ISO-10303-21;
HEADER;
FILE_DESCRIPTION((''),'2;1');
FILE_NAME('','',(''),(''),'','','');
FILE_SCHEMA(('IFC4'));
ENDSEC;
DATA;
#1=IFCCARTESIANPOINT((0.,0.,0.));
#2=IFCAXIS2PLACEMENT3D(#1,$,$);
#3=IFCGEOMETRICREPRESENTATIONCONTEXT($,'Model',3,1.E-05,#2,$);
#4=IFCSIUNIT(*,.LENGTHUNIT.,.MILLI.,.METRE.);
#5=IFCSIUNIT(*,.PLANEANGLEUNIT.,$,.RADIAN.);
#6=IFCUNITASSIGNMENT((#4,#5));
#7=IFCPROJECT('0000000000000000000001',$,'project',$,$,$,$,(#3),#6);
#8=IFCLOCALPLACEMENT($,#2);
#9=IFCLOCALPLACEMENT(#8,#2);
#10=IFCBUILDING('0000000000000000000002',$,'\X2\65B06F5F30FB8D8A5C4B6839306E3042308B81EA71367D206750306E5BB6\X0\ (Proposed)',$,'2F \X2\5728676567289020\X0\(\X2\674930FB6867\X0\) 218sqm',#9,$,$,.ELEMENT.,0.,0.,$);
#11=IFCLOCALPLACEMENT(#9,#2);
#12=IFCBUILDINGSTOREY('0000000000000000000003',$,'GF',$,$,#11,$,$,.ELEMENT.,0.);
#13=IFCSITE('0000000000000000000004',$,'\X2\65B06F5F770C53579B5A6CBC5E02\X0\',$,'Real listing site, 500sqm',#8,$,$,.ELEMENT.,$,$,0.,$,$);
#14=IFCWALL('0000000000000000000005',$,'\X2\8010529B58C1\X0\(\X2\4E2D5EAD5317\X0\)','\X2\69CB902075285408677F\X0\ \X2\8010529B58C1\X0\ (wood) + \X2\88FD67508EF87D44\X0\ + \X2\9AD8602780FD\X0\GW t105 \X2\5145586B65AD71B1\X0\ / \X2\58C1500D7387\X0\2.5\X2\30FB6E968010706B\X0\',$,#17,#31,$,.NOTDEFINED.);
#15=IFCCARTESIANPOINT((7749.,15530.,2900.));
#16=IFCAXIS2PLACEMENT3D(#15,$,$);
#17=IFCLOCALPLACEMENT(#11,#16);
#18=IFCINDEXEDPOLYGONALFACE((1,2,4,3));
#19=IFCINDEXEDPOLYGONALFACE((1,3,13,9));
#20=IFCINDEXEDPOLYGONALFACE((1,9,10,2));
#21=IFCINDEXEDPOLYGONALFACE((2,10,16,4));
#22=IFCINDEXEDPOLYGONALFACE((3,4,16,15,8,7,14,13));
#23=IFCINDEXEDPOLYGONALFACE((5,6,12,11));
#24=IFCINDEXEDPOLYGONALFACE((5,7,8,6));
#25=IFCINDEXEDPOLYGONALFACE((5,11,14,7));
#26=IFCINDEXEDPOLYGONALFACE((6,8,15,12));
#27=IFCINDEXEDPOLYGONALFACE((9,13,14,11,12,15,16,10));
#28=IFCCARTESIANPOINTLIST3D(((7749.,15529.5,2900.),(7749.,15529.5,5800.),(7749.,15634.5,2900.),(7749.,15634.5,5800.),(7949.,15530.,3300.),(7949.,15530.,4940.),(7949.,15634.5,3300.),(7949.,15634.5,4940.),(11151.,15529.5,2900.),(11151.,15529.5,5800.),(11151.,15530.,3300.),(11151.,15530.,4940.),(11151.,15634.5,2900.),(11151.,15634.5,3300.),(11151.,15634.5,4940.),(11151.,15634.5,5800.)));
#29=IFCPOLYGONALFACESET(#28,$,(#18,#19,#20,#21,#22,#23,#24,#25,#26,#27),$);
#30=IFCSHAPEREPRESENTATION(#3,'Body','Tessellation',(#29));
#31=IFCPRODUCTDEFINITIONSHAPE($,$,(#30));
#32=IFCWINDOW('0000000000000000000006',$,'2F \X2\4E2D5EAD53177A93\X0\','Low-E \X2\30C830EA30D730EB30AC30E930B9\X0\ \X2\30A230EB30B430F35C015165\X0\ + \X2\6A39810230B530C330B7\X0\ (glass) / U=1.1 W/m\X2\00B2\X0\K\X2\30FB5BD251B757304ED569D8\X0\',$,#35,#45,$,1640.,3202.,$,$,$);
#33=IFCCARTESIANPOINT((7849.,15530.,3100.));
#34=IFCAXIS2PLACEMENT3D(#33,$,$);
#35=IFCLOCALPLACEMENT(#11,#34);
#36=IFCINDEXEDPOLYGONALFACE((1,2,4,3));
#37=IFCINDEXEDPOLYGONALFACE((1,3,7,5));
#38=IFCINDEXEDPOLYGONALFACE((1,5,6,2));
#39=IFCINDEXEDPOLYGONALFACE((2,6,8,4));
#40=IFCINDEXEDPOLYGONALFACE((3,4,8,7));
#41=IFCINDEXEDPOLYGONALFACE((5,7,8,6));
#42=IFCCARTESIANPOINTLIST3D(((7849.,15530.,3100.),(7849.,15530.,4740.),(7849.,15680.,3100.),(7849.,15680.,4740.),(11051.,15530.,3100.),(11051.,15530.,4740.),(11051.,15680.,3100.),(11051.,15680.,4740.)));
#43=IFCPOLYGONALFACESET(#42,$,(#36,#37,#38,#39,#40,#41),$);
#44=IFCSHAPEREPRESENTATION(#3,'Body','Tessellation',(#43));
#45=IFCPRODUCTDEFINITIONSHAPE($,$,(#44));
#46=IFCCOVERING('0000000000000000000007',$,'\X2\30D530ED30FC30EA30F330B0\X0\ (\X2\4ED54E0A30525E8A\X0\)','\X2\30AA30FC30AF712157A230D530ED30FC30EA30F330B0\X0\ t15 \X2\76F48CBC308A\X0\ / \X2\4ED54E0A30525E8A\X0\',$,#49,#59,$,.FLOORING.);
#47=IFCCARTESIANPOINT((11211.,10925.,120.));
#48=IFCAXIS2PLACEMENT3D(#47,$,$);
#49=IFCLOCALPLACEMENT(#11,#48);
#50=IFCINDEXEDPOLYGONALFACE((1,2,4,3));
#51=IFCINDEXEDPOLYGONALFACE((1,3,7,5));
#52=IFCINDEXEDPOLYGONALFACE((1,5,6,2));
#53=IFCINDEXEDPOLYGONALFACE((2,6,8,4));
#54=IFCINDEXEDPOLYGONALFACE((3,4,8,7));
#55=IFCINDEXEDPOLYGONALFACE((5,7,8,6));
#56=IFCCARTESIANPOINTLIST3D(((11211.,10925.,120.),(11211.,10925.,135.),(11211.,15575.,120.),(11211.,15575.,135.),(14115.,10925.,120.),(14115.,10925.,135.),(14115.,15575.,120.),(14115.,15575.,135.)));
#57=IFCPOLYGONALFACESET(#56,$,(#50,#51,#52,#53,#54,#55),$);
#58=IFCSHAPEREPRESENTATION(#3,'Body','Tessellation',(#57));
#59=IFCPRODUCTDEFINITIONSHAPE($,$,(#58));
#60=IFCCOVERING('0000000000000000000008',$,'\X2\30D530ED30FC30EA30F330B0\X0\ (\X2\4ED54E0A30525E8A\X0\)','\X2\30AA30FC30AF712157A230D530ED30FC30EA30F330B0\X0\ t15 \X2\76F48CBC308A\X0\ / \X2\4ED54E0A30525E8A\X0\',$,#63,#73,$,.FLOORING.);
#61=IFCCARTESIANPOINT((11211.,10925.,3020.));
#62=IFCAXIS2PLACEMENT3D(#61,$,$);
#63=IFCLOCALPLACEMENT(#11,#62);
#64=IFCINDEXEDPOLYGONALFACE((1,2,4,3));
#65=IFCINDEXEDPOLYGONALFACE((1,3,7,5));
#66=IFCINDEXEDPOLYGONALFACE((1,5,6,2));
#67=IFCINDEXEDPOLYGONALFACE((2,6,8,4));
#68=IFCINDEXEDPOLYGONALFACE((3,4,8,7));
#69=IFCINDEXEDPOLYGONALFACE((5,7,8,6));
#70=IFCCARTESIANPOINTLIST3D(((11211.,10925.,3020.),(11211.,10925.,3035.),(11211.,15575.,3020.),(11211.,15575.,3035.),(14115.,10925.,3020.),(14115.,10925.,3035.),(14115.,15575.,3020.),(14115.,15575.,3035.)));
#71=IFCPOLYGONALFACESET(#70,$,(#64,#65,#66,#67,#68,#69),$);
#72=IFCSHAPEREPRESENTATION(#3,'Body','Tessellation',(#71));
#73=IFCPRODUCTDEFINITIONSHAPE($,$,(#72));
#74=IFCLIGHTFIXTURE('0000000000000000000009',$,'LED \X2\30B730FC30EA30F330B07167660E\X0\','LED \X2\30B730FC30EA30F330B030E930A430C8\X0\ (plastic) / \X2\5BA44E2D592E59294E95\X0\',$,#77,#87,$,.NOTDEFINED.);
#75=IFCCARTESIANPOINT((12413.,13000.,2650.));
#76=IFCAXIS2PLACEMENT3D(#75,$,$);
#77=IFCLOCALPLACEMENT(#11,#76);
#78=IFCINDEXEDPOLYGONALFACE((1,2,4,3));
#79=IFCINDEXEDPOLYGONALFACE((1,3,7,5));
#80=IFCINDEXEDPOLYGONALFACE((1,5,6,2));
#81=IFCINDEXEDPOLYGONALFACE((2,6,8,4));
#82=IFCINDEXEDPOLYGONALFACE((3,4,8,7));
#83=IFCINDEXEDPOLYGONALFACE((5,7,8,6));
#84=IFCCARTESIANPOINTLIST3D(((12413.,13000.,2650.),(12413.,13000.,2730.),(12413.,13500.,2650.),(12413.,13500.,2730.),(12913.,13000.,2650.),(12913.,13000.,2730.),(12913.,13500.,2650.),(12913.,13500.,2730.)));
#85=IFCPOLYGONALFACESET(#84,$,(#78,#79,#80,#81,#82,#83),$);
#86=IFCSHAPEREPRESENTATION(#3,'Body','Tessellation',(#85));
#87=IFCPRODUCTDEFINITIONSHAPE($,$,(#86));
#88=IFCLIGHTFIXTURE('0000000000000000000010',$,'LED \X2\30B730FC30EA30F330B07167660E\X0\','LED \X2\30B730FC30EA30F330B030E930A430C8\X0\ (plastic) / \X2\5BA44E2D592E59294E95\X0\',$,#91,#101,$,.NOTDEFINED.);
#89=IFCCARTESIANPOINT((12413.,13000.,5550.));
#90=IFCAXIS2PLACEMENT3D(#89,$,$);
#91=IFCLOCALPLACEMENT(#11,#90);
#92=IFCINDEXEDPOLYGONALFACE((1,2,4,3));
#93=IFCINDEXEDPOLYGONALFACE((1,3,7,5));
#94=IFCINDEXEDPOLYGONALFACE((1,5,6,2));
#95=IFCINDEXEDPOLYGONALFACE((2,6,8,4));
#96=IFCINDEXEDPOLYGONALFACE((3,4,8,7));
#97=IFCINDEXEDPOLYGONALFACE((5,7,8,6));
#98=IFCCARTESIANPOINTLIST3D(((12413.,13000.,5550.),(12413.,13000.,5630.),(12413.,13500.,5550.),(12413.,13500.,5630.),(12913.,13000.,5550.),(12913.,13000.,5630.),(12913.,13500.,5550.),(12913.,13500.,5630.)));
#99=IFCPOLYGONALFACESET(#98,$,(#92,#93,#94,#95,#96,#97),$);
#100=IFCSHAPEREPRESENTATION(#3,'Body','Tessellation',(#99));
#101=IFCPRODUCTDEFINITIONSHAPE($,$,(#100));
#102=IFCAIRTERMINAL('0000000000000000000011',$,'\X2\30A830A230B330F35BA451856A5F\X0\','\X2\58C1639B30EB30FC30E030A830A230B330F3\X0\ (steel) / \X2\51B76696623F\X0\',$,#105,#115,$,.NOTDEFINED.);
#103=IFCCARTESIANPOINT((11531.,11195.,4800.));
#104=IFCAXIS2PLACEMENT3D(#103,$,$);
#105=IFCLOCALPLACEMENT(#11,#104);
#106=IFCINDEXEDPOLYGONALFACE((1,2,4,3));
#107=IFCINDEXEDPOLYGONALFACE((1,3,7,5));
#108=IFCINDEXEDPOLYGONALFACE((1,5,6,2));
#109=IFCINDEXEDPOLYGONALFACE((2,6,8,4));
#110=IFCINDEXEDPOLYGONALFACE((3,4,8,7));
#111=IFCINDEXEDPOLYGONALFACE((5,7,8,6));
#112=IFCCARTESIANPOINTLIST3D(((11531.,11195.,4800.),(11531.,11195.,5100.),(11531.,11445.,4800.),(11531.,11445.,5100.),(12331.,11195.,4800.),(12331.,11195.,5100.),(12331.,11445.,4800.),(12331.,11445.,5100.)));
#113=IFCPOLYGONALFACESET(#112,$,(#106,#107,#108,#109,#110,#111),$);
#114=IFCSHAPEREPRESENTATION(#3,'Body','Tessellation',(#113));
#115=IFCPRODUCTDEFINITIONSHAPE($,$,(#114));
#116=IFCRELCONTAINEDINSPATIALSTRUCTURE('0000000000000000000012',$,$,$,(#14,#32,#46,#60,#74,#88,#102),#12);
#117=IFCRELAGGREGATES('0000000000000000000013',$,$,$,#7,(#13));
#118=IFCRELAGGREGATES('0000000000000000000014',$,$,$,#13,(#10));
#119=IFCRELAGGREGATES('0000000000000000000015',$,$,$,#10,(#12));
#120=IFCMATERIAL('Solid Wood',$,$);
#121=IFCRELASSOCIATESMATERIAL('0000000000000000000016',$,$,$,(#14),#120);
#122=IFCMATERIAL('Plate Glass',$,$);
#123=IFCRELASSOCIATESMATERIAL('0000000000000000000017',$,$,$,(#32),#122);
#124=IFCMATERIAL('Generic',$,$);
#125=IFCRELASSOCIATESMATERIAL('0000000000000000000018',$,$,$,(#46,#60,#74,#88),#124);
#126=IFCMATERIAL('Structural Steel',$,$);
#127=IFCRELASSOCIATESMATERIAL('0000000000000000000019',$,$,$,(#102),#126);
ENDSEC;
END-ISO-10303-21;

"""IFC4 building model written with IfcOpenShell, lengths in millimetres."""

from ifc_helpers import new_model, si_unit, frame, frame_2d, origin, place, context, project, spatial, rectangle, extrude, material, element, fill, save


model = new_model("IFC4")

# Units and contexts
model_context = context("Model", 3, precision=1e-05, world=origin())
ifc_project = project(units=[si_unit("LENGTHUNIT", "METRE", prefix="MILLI"), si_unit("PLANEANGLEUNIT", "RADIAN")], contexts=[model_context])

# Site, building, storey
site_placement = place(None, origin())
site = spatial("IfcSite", under=ifc_project, at=site_placement, Name="新潟県南魚沼市", ObjectType="Real listing site, 500sqm", CompositionType="ELEMENT", RefElevation=0.0)
building_placement = place(site_placement, origin())
building = spatial("IfcBuilding", under=site, at=building_placement, Name="新潟・越屋根のある自然素材の家 (Proposed)", ObjectType="2F 在来木造(杉・桧) 218sqm", CompositionType="ELEMENT", ElevationOfRefHeight=0.0, ElevationOfTerrain=0.0)
storey_placement = place(building_placement, origin())
storey = spatial("IfcBuildingStorey", under=building, at=storey_placement, Name="GF", CompositionType="ELEMENT", Elevation=0.0)

# Shared definitions
ifc_material_1 = material(Name="Solid Wood")

# Wall, opening, window
ifc_material_2 = material(Name="Plate Glass")
wall_1_placement = place(storey_placement, frame((7749.0, 15530.0, 2900.0)))
wall_1 = element("IfcWall", 1, at=wall_1_placement, inside=storey, material=ifc_material_1, Name="耐力壁(中庭北)", Description="構造用合板 耐力壁 (wood) + 製材軸組 + 高性能GW t105 充填断熱 / 壁倍率2.5・準耐火", PredefinedType="NOTDEFINED", context=model_context, shape_type="SweptSolid", body=[
    extrude(rectangle(XDim=3402.0, YDim=105.0, at=frame_2d((1701.0, 52.0))), frame((7749.0, 15530.0, 2900.0)), (0.0, 0.0, 1.0), 2900.0),
])
opening_1_placement = place(storey_placement, frame((7849.0, 15530.0, 3100.0)))
opening_1 = element("IfcOpeningElement", 2, at=opening_1_placement, cuts=wall_1, PredefinedType="NOTDEFINED", context=model_context, shape_type="SweptSolid", body=[
    extrude(rectangle(XDim=3202.0, YDim=150.0, at=frame_2d((1601.0, 75.0))), frame((7849.0, 15530.0, 3100.0)), (0.0, 0.0, 1.0), 1640.0),
])
window_1_placement = place(storey_placement, frame((7849.0, 15530.0, 3100.0)))
window_1 = element("IfcWindow", 3, at=window_1_placement, inside=storey, material=ifc_material_2, Name="2F 中庭北窓", Description="Low-E トリプルガラス アルゴン封入 + 樹脂サッシ (glass) / U=1.1 W/m²K・寒冷地仕様", OverallHeight=1640.0, OverallWidth=3202.0, context=model_context, shape_type="SweptSolid", body=[
    extrude(rectangle(XDim=3202.0, YDim=150.0, at=frame_2d((1601.0, 75.0))), frame((7849.0, 15530.0, 3100.0)), (0.0, 0.0, 1.0), 1640.0),
])
fill(opening_1, window_1)

# Coverings
ifc_material_3 = material(Name="Generic")
covering_1_placement = place(storey_placement, frame((11211.0, 10925.0, 120.0)))
element("IfcCovering", 4, at=covering_1_placement, inside=storey, material=ifc_material_3, Name="フローリング (仕上げ床)", Description="オーク無垢フローリング t15 直貼り / 仕上げ床", PredefinedType="FLOORING", context=model_context, shape_type="SweptSolid", body=[
    extrude(rectangle(XDim=2904.0, YDim=4650.0, at=frame_2d((1452.0, 2325.0))), frame((11211.0, 10925.0, 120.0)), (0.0, 0.0, 1.0), 15.0),
])
covering_2_placement = place(storey_placement, frame((11211.0, 10925.0, 3020.0)))
element("IfcCovering", 5, at=covering_2_placement, inside=storey, material=ifc_material_3, Name="フローリング (仕上げ床)", Description="オーク無垢フローリング t15 直貼り / 仕上げ床", PredefinedType="FLOORING", context=model_context, shape_type="SweptSolid", body=[
    extrude(rectangle(XDim=2904.0, YDim=4650.0, at=frame_2d((1452.0, 2325.0))), frame((11211.0, 10925.0, 3020.0)), (0.0, 0.0, 1.0), 15.0),
])

# Light fixtures
light_fixture_1_placement = place(storey_placement, frame((12413.0, 13000.0, 2650.0)))
element("IfcLightFixture", 6, at=light_fixture_1_placement, inside=storey, material=ifc_material_3, Name="LED シーリング照明", Description="LED シーリングライト (plastic) / 室中央天井", PredefinedType="NOTDEFINED", context=model_context, shape_type="SweptSolid", body=[
    extrude(rectangle(XDim=500.0, YDim=500.0, at=frame_2d((250.0, 250.0))), frame((12413.0, 13000.0, 2650.0)), (0.0, 0.0, 1.0), 80.0),
])
light_fixture_2_placement = place(storey_placement, frame((12413.0, 13000.0, 5550.0)))
element("IfcLightFixture", 7, at=light_fixture_2_placement, inside=storey, material=ifc_material_3, Name="LED シーリング照明", Description="LED シーリングライト (plastic) / 室中央天井", PredefinedType="NOTDEFINED", context=model_context, shape_type="SweptSolid", body=[
    extrude(rectangle(XDim=500.0, YDim=500.0, at=frame_2d((250.0, 250.0))), frame((12413.0, 13000.0, 5550.0)), (0.0, 0.0, 1.0), 80.0),
])

# Air terminal
ifc_material_4 = material(Name="Structural Steel")
air_terminal_placement = place(storey_placement, frame((11531.0, 11195.0, 4800.0)))
element("IfcAirTerminal", 8, at=air_terminal_placement, inside=storey, material=ifc_material_4, Name="エアコン室内機", Description="壁掛ルームエアコン (steel) / 冷暖房", PredefinedType="NOTDEFINED", context=model_context, shape_type="SweptSolid", body=[
    extrude(rectangle(XDim=800.0, YDim=250.0, at=frame_2d((400.0, 125.0))), frame((11531.0, 11195.0, 4800.0)), (0.0, 0.0, 1.0), 300.0),
])

save(model, "model.ifc")
